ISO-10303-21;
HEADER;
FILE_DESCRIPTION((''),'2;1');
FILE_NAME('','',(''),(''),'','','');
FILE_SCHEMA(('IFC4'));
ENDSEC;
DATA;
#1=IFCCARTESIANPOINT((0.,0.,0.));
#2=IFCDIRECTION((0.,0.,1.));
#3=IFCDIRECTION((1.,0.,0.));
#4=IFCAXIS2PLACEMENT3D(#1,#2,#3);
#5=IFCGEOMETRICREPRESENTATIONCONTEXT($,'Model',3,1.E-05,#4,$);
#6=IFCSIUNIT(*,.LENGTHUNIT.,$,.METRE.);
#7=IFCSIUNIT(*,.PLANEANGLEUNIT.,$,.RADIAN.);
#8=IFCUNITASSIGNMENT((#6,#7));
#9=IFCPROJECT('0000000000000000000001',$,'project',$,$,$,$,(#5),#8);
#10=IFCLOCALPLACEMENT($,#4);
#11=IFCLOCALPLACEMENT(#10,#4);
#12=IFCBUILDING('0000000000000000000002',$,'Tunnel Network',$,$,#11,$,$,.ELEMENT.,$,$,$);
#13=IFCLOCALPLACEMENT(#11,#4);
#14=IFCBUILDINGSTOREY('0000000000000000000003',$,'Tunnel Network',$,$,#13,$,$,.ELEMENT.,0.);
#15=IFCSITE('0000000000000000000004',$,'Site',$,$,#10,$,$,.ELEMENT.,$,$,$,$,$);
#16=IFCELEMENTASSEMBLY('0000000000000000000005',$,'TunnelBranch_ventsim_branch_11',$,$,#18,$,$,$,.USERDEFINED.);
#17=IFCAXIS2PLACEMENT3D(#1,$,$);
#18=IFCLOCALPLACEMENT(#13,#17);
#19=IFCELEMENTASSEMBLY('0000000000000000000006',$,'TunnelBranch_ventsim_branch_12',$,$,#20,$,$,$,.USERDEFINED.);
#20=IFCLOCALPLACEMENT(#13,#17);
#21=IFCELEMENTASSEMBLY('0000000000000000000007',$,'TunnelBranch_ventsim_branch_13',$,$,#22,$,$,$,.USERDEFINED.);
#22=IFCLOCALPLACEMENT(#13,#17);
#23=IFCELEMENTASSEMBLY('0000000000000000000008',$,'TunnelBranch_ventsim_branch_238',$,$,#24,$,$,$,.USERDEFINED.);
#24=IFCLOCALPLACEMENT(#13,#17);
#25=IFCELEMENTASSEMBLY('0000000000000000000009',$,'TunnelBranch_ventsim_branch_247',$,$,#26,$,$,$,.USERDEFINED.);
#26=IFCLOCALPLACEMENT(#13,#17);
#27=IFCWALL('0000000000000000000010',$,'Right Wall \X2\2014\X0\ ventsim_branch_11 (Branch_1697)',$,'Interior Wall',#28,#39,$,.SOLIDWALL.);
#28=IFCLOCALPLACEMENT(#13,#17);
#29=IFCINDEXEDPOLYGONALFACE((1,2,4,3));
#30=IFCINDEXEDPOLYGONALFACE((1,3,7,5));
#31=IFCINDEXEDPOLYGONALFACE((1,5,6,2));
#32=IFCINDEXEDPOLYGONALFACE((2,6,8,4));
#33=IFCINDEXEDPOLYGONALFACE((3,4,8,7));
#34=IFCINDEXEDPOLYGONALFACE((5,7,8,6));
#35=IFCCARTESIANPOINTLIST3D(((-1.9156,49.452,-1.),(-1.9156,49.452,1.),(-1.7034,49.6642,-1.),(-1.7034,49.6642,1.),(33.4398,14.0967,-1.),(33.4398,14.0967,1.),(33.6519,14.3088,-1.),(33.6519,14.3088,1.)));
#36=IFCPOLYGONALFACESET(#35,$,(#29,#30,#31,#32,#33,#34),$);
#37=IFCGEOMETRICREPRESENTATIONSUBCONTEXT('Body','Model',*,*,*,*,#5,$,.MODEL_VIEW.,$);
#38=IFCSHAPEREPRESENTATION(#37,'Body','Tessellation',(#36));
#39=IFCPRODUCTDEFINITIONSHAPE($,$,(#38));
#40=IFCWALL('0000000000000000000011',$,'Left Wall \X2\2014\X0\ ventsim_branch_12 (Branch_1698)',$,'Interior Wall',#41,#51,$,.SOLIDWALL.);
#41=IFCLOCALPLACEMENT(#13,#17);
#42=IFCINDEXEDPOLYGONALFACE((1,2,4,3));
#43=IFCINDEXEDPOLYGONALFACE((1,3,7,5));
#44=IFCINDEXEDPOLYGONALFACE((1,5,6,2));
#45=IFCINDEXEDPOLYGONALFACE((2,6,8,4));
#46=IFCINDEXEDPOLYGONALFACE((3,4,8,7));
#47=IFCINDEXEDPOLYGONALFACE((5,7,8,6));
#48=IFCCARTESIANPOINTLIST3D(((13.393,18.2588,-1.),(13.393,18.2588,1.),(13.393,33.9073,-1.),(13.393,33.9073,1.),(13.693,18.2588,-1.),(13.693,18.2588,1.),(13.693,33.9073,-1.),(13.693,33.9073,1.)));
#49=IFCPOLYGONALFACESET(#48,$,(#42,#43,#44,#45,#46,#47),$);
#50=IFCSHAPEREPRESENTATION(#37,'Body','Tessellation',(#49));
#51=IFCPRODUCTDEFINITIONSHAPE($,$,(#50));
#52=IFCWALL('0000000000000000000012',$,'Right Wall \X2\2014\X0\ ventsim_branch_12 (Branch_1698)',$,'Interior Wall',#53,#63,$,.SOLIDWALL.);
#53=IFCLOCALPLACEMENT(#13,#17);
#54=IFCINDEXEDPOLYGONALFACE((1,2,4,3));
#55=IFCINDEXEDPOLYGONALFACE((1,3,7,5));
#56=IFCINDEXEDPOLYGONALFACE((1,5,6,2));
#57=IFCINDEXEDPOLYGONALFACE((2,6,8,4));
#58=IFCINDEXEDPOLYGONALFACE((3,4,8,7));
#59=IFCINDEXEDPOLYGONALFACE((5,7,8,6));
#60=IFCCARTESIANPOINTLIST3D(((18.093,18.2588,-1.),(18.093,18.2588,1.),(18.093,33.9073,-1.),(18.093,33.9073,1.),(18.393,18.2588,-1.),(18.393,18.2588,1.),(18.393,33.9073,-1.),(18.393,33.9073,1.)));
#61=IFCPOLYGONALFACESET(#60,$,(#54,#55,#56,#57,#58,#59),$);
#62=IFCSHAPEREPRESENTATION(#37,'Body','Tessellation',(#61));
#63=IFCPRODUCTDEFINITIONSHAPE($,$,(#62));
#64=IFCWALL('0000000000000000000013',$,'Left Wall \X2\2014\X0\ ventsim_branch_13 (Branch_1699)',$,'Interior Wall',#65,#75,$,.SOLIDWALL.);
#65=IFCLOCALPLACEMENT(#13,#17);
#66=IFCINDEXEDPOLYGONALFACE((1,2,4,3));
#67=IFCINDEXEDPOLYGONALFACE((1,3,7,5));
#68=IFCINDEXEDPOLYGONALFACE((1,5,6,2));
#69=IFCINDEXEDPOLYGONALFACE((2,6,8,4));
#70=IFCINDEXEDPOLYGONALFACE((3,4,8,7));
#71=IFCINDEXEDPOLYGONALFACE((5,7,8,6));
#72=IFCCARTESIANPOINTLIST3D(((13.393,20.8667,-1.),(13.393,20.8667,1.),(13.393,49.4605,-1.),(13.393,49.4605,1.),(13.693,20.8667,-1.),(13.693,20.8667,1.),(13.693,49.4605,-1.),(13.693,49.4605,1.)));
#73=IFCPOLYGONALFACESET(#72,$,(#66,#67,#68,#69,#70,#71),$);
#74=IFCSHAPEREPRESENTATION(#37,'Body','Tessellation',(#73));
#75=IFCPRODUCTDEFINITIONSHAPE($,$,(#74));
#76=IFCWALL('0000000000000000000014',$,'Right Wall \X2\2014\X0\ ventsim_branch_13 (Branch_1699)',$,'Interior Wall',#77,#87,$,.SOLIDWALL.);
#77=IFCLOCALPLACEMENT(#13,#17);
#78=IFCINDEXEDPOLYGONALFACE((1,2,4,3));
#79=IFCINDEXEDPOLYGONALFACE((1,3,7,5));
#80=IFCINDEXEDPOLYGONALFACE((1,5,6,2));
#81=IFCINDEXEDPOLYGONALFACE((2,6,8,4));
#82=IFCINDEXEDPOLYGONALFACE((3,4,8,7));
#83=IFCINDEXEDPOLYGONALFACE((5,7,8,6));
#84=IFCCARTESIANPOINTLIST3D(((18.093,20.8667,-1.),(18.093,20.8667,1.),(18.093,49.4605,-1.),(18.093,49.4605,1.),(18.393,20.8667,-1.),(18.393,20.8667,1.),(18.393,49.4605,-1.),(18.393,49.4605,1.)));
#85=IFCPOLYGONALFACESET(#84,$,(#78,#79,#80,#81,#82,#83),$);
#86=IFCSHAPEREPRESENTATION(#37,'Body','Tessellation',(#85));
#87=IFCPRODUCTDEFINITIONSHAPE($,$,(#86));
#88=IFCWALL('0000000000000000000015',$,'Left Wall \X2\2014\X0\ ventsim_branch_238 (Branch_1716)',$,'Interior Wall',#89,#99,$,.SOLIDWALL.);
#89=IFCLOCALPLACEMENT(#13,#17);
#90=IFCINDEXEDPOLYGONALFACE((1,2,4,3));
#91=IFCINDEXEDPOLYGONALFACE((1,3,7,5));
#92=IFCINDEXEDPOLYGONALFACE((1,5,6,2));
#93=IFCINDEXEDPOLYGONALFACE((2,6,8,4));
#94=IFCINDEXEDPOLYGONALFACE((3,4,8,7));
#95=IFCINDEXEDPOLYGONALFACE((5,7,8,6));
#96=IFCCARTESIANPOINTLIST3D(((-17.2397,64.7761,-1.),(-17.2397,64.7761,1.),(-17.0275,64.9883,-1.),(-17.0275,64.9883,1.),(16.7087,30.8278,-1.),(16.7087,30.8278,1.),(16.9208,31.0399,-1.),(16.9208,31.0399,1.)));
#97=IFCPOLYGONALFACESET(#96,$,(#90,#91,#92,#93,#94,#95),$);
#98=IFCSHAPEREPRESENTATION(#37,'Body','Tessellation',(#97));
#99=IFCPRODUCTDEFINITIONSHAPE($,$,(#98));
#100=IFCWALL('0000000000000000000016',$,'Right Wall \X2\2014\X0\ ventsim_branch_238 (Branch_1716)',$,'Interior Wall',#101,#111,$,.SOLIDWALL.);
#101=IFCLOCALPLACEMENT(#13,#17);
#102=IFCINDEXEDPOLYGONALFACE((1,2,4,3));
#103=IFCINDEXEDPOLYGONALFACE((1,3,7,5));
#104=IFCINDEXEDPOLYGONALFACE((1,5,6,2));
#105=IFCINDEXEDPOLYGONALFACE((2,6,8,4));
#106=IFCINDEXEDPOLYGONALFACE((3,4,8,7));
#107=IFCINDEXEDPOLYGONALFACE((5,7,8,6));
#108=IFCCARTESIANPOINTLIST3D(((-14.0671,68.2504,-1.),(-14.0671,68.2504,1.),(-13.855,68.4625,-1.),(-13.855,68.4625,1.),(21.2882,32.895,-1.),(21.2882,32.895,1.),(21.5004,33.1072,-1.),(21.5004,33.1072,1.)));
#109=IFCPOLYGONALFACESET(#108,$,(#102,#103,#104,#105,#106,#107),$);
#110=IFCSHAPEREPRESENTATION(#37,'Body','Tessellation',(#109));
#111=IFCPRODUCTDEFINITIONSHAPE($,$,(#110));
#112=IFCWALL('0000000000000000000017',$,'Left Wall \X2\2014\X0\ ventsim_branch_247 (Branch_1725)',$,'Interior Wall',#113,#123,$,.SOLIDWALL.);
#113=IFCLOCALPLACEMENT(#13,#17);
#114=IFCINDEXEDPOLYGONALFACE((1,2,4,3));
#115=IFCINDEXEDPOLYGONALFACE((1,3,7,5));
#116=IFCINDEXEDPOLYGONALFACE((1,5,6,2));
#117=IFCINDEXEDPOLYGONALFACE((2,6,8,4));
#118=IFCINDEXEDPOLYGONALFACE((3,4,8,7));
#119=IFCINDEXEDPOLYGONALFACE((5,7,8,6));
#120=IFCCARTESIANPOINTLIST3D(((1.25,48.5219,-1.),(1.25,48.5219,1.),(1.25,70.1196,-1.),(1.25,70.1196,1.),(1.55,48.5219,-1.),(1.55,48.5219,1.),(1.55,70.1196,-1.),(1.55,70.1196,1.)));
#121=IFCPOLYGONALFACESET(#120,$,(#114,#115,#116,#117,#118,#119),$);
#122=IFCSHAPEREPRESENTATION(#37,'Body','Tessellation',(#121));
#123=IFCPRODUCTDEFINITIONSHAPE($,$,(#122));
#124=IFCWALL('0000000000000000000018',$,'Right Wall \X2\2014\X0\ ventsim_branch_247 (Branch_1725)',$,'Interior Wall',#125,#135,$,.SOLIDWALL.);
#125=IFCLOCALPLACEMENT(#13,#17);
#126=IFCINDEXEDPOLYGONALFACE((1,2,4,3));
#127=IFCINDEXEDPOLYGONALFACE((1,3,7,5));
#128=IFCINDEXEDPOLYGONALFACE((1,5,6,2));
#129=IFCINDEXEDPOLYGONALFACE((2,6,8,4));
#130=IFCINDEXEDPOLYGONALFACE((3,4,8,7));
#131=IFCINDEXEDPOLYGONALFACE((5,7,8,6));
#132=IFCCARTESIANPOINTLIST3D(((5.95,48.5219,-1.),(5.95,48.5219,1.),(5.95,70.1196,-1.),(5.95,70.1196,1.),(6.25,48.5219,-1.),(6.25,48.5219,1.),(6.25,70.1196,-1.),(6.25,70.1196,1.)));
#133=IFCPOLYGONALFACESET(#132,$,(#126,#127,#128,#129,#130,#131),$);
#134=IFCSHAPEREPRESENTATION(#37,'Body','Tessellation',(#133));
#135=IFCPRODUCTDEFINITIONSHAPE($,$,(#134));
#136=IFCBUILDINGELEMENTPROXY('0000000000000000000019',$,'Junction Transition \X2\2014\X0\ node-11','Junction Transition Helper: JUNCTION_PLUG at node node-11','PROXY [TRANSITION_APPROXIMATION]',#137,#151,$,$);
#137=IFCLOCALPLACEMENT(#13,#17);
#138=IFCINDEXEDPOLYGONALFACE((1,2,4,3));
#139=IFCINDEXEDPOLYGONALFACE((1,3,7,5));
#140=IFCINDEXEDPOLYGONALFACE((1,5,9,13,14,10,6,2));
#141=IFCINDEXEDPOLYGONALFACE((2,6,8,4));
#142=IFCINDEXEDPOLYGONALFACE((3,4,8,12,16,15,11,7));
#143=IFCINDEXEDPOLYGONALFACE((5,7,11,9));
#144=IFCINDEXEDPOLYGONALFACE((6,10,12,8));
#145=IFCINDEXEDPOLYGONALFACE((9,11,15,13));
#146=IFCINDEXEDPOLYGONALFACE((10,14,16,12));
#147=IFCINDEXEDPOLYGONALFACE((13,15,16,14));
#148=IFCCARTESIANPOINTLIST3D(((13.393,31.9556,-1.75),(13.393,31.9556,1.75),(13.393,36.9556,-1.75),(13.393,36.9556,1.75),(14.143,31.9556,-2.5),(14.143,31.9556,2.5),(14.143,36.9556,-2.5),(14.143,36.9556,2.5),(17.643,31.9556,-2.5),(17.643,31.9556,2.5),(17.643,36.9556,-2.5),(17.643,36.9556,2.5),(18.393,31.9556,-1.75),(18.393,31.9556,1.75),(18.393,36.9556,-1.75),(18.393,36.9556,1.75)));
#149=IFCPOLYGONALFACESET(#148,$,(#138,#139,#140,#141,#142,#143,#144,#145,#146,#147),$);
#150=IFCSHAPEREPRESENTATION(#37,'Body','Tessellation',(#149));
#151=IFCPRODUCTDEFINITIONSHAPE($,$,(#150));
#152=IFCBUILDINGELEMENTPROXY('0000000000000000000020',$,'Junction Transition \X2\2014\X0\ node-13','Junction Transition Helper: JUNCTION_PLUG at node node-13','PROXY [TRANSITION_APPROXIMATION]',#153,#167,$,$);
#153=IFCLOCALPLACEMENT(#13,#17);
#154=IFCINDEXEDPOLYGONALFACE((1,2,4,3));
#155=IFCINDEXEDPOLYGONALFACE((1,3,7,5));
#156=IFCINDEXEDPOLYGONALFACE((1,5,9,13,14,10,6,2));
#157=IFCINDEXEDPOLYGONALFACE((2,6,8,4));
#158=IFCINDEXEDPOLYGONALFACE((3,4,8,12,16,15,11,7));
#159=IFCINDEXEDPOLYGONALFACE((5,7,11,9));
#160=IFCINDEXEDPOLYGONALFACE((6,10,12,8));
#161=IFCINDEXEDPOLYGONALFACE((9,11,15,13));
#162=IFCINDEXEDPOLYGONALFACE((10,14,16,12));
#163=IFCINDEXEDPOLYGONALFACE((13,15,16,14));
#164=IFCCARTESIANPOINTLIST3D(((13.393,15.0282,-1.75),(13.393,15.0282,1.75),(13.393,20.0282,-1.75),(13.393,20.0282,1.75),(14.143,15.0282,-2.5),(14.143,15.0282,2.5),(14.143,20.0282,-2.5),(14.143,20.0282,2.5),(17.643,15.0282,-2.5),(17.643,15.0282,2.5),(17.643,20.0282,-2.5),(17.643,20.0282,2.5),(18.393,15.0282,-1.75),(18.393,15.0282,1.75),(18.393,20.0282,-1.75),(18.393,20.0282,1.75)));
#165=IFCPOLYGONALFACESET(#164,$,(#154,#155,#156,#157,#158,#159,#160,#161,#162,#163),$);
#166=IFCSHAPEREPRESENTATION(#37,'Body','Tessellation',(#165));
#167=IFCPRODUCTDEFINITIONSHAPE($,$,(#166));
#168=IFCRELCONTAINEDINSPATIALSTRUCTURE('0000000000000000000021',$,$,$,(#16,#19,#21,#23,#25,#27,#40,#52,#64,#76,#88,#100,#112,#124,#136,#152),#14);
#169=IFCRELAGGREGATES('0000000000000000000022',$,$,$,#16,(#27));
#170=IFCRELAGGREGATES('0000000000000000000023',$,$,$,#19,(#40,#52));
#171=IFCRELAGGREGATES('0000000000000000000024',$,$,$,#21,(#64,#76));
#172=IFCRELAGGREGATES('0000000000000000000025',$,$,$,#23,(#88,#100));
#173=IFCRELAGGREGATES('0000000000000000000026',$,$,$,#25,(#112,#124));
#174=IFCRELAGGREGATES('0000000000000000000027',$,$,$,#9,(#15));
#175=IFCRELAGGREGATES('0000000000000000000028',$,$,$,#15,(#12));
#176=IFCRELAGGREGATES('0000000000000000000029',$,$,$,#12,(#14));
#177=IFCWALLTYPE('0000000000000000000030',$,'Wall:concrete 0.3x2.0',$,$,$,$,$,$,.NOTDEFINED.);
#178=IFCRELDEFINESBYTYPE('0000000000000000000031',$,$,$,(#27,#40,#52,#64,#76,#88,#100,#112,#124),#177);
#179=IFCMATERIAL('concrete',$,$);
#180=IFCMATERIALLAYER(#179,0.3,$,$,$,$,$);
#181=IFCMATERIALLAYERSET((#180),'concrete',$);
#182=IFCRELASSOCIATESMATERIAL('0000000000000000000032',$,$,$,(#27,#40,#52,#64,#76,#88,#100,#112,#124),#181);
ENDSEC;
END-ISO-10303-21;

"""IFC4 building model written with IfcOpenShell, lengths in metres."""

from ifc_helpers import new_model, si_unit, frame, origin_with_axes, origin_2d_with_axis, place, context, subcontext, project, spatial, polyline, rectangle, outline, extrude, material, layer, layer_set, layer_usage, type_object, element, aggregate, save


model = new_model("IFC4")

# Units and contexts
model_context = context("Model", 3, precision=1e-05, world=origin_with_axes())
body_context = subcontext(model_context, "Body", "Model", "MODEL_VIEW")
ifc_project = project(units=[si_unit("LENGTHUNIT", "METRE"), si_unit("PLANEANGLEUNIT", "RADIAN")], contexts=[model_context])

# Site, building, storey
site_placement = place(None, origin_with_axes())
site = spatial("IfcSite", under=ifc_project, at=site_placement, Name="Site", CompositionType="ELEMENT")
building_placement = place(site_placement, origin_with_axes())
building = spatial("IfcBuilding", under=site, at=building_placement, Name="Tunnel Network", CompositionType="ELEMENT")
storey_placement = place(building_placement, origin_with_axes())
storey = spatial("IfcBuildingStorey", under=building, at=storey_placement, Name="Tunnel Network", CompositionType="ELEMENT", Elevation=0.0)

# Element assemblies
assembly_1_placement = place(storey_placement, frame((3.8757, 50.5197, 0.0), z_axis=(0.707107, -0.707107, 0.0), x_axis=(-0.707107, -0.707107, 0.0)))
assembly_1 = element("IfcElementAssembly", 1, at=assembly_1_placement, inside=storey, Name="TunnelBranch_ventsim_branch_11", PredefinedType="USERDEFINED")
ifc_material_1 = material(Name="concrete")
ifc_layer_1 = layer(ifc_material_1, 0.3)
ifc_layer_set_1 = layer_set([ifc_layer_1], Name="concrete")
assembly_2_placement = place(storey_placement, frame((13.543, 18.2588, 0.0), z_axis=(0.0, 1.0, 0.0), x_axis=(1.0, 0.0, 0.0)))
assembly_2 = element("IfcElementAssembly", 2, at=assembly_2_placement, inside=storey, Name="TunnelBranch_ventsim_branch_12", PredefinedType="USERDEFINED")
assembly_3_placement = place(storey_placement, frame((13.543, 20.8667, 0.0), z_axis=(0.0, 1.0, 0.0), x_axis=(1.0, 0.0, 0.0)))
assembly_3 = element("IfcElementAssembly", 3, at=assembly_3_placement, inside=storey, Name="TunnelBranch_ventsim_branch_13", PredefinedType="USERDEFINED")
assembly_4_placement = place(storey_placement, frame((16.8148, 30.9338, 0.0), z_axis=(-0.707107, 0.707107, 0.0), x_axis=(0.707107, 0.707107, 0.0)))
assembly_4 = element("IfcElementAssembly", 4, at=assembly_4_placement, inside=storey, Name="TunnelBranch_ventsim_branch_238", PredefinedType="USERDEFINED")
assembly_5_placement = place(storey_placement, frame((1.4, 48.5219, 0.0), z_axis=(0.0, 1.0, 0.0), x_axis=(1.0, 0.0, 0.0)))
assembly_5 = element("IfcElementAssembly", 5, at=assembly_5_placement, inside=storey, Name="TunnelBranch_ventsim_branch_247", PredefinedType="USERDEFINED")

# Walls
ifc_layer_usage_1 = layer_usage(ifc_layer_set_1, "AXIS2", "POSITIVE", 0.0)
wall_type_1 = type_object("IfcWallType", Name="Wall:concrete 0.3x2.0")
wall_1_placement = place(storey_placement, frame((-1.8095, 49.5581, 0.0), z_axis=(0.707107, -0.707107, 0.0), x_axis=(-0.707107, -0.707107, 0.0)))
wall_1 = element("IfcWall", 6, at=wall_1_placement, inside=storey, type_object=wall_type_1, material=ifc_layer_usage_1, Name="Right Wall — ventsim_branch_11 (Branch_1697)", ObjectType="Interior Wall", PredefinedType="SOLIDWALL", context=body_context, shape_type="SweptSolid", body=[
    extrude(rectangle(XDim=0.3, YDim=2.0, at=origin_2d_with_axis()), origin_with_axes(), (0.0, 0.0, 1.0), 50.0),
])
aggregate(assembly_1, [wall_1])
ifc_layer_usage_2 = layer_usage(ifc_layer_set_1, "AXIS2", "POSITIVE", 0.0)
wall_2_placement = place(storey_placement, frame((13.543, 18.2588, 0.0), z_axis=(0.0, 1.0, 0.0), x_axis=(1.0, 0.0, 0.0)))
wall_2 = element("IfcWall", 7, at=wall_2_placement, inside=storey, type_object=wall_type_1, material=ifc_layer_usage_2, Name="Left Wall — ventsim_branch_12 (Branch_1698)", ObjectType="Interior Wall", PredefinedType="SOLIDWALL", context=body_context, shape_type="SweptSolid", body=[
    extrude(rectangle(XDim=0.3, YDim=2.0, at=origin_2d_with_axis()), origin_with_axes(), (0.0, 0.0, 1.0), 15.6485),
])
ifc_layer_usage_3 = layer_usage(ifc_layer_set_1, "AXIS2", "POSITIVE", 0.0)
wall_3_placement = place(storey_placement, frame((18.243, 18.2588, 0.0), z_axis=(0.0, 1.0, 0.0), x_axis=(1.0, 0.0, 0.0)))
wall_3 = element("IfcWall", 8, at=wall_3_placement, inside=storey, type_object=wall_type_1, material=ifc_layer_usage_3, Name="Right Wall — ventsim_branch_12 (Branch_1698)", ObjectType="Interior Wall", PredefinedType="SOLIDWALL", context=body_context, shape_type="SweptSolid", body=[
    extrude(rectangle(XDim=0.3, YDim=2.0, at=origin_2d_with_axis()), origin_with_axes(), (0.0, 0.0, 1.0), 15.6485),
])
aggregate(assembly_2, [wall_2, wall_3])
ifc_layer_usage_4 = layer_usage(ifc_layer_set_1, "AXIS2", "POSITIVE", 0.0)
wall_4_placement = place(storey_placement, frame((13.543, 20.8667, 0.0), z_axis=(0.0, 1.0, 0.0), x_axis=(1.0, 0.0, 0.0)))
wall_4 = element("IfcWall", 9, at=wall_4_placement, inside=storey, type_object=wall_type_1, material=ifc_layer_usage_4, Name="Left Wall — ventsim_branch_13 (Branch_1699)", ObjectType="Interior Wall", PredefinedType="SOLIDWALL", context=body_context, shape_type="SweptSolid", body=[
    extrude(rectangle(XDim=0.3, YDim=2.0, at=origin_2d_with_axis()), origin_with_axes(), (0.0, 0.0, 1.0), 28.5938),
])
ifc_layer_usage_5 = layer_usage(ifc_layer_set_1, "AXIS2", "POSITIVE", 0.0)
wall_5_placement = place(storey_placement, frame((18.243, 20.8667, 0.0), z_axis=(0.0, 1.0, 0.0), x_axis=(1.0, 0.0, 0.0)))
wall_5 = element("IfcWall", 10, at=wall_5_placement, inside=storey, type_object=wall_type_1, material=ifc_layer_usage_5, Name="Right Wall — ventsim_branch_13 (Branch_1699)", ObjectType="Interior Wall", PredefinedType="SOLIDWALL", context=body_context, shape_type="SweptSolid", body=[
    extrude(rectangle(XDim=0.3, YDim=2.0, at=origin_2d_with_axis()), origin_with_axes(), (0.0, 0.0, 1.0), 28.5938),
])
aggregate(assembly_3, [wall_4, wall_5])
ifc_layer_usage_6 = layer_usage(ifc_layer_set_1, "AXIS2", "POSITIVE", 0.0)
wall_6_placement = place(storey_placement, frame((16.8148, 30.9338, 0.0), z_axis=(-0.707107, 0.707107, 0.0), x_axis=(0.707107, 0.707107, 0.0)))
wall_6 = element("IfcWall", 11, at=wall_6_placement, inside=storey, type_object=wall_type_1, material=ifc_layer_usage_6, Name="Left Wall — ventsim_branch_238 (Branch_1716)", ObjectType="Interior Wall", PredefinedType="SOLIDWALL", context=body_context, shape_type="SweptSolid", body=[
    extrude(rectangle(XDim=0.3, YDim=2.0, at=origin_2d_with_axis()), origin_with_axes(), (0.0, 0.0, 1.0), 48.0102),
])
ifc_layer_usage_7 = layer_usage(ifc_layer_set_1, "AXIS2", "POSITIVE", 0.0)
wall_7_placement = place(storey_placement, frame((21.3943, 33.0011, 0.0), z_axis=(-0.707107, 0.707107, 0.0), x_axis=(0.707107, 0.707107, 0.0)))
wall_7 = element("IfcWall", 12, at=wall_7_placement, inside=storey, type_object=wall_type_1, material=ifc_layer_usage_7, Name="Right Wall — ventsim_branch_238 (Branch_1716)", ObjectType="Interior Wall", PredefinedType="SOLIDWALL", context=body_context, shape_type="SweptSolid", body=[
    extrude(rectangle(XDim=0.3, YDim=2.0, at=origin_2d_with_axis()), origin_with_axes(), (0.0, 0.0, 1.0), 50.0),
])
aggregate(assembly_4, [wall_6, wall_7])
ifc_layer_usage_8 = layer_usage(ifc_layer_set_1, "AXIS2", "POSITIVE", 0.0)
wall_8_placement = place(storey_placement, frame((1.4, 48.5219, 0.0), z_axis=(0.0, 1.0, 0.0), x_axis=(1.0, 0.0, 0.0)))
wall_8 = element("IfcWall", 13, at=wall_8_placement, inside=storey, type_object=wall_type_1, material=ifc_layer_usage_8, Name="Left Wall — ventsim_branch_247 (Branch_1725)", ObjectType="Interior Wall", PredefinedType="SOLIDWALL", context=body_context, shape_type="SweptSolid", body=[
    extrude(rectangle(XDim=0.3, YDim=2.0, at=origin_2d_with_axis()), origin_with_axes(), (0.0, 0.0, 1.0), 21.5977),
])
ifc_layer_usage_9 = layer_usage(ifc_layer_set_1, "AXIS2", "POSITIVE", 0.0)
wall_9_placement = place(storey_placement, frame((6.1, 48.5219, 0.0), z_axis=(0.0, 1.0, 0.0), x_axis=(1.0, 0.0, 0.0)))
wall_9 = element("IfcWall", 14, at=wall_9_placement, inside=storey, type_object=wall_type_1, material=ifc_layer_usage_9, Name="Right Wall — ventsim_branch_247 (Branch_1725)", ObjectType="Interior Wall", PredefinedType="SOLIDWALL", context=body_context, shape_type="SweptSolid", body=[
    extrude(rectangle(XDim=0.3, YDim=2.0, at=origin_2d_with_axis()), origin_with_axes(), (0.0, 0.0, 1.0), 21.5977),
])
aggregate(assembly_5, [wall_8, wall_9])

# Building element proxies
for number, where, z_axis, x_axis, name, description in (
    (15, (15.893, 31.9556, 0.0), (0.0, 1.0, 0.0), (1.0, 0.0, 0.0), "Junction Transition — node-11", "Junction Transition Helper: JUNCTION_PLUG at node node-11"),
    (16, (15.893, 15.0282, 0.0), (0.0, 1.0, 0.0), (1.0, 0.0, 0.0), "Junction Transition — node-13", "Junction Transition Helper: JUNCTION_PLUG at node node-13"),
):
    element("IfcBuildingElementProxy", number, at=place(storey_placement, frame(where, z_axis=z_axis, x_axis=x_axis)), inside=storey, Name=name, Description=description, ObjectType="PROXY [TRANSITION_APPROXIMATION]", context=body_context, shape_type="SweptSolid", body=[
        extrude(outline(polyline([(1.75, 2.5), (2.5, 1.75), (2.5, -1.75), (1.75, -2.5), (-1.75, -2.5), (-2.5, -1.75), (-2.5, 1.75), (-1.75, 2.5), (1.75, 2.5)])), origin_with_axes(), (0.0, 0.0, 1.0), 5.0),
    ])

save(model, "model.ifc")
